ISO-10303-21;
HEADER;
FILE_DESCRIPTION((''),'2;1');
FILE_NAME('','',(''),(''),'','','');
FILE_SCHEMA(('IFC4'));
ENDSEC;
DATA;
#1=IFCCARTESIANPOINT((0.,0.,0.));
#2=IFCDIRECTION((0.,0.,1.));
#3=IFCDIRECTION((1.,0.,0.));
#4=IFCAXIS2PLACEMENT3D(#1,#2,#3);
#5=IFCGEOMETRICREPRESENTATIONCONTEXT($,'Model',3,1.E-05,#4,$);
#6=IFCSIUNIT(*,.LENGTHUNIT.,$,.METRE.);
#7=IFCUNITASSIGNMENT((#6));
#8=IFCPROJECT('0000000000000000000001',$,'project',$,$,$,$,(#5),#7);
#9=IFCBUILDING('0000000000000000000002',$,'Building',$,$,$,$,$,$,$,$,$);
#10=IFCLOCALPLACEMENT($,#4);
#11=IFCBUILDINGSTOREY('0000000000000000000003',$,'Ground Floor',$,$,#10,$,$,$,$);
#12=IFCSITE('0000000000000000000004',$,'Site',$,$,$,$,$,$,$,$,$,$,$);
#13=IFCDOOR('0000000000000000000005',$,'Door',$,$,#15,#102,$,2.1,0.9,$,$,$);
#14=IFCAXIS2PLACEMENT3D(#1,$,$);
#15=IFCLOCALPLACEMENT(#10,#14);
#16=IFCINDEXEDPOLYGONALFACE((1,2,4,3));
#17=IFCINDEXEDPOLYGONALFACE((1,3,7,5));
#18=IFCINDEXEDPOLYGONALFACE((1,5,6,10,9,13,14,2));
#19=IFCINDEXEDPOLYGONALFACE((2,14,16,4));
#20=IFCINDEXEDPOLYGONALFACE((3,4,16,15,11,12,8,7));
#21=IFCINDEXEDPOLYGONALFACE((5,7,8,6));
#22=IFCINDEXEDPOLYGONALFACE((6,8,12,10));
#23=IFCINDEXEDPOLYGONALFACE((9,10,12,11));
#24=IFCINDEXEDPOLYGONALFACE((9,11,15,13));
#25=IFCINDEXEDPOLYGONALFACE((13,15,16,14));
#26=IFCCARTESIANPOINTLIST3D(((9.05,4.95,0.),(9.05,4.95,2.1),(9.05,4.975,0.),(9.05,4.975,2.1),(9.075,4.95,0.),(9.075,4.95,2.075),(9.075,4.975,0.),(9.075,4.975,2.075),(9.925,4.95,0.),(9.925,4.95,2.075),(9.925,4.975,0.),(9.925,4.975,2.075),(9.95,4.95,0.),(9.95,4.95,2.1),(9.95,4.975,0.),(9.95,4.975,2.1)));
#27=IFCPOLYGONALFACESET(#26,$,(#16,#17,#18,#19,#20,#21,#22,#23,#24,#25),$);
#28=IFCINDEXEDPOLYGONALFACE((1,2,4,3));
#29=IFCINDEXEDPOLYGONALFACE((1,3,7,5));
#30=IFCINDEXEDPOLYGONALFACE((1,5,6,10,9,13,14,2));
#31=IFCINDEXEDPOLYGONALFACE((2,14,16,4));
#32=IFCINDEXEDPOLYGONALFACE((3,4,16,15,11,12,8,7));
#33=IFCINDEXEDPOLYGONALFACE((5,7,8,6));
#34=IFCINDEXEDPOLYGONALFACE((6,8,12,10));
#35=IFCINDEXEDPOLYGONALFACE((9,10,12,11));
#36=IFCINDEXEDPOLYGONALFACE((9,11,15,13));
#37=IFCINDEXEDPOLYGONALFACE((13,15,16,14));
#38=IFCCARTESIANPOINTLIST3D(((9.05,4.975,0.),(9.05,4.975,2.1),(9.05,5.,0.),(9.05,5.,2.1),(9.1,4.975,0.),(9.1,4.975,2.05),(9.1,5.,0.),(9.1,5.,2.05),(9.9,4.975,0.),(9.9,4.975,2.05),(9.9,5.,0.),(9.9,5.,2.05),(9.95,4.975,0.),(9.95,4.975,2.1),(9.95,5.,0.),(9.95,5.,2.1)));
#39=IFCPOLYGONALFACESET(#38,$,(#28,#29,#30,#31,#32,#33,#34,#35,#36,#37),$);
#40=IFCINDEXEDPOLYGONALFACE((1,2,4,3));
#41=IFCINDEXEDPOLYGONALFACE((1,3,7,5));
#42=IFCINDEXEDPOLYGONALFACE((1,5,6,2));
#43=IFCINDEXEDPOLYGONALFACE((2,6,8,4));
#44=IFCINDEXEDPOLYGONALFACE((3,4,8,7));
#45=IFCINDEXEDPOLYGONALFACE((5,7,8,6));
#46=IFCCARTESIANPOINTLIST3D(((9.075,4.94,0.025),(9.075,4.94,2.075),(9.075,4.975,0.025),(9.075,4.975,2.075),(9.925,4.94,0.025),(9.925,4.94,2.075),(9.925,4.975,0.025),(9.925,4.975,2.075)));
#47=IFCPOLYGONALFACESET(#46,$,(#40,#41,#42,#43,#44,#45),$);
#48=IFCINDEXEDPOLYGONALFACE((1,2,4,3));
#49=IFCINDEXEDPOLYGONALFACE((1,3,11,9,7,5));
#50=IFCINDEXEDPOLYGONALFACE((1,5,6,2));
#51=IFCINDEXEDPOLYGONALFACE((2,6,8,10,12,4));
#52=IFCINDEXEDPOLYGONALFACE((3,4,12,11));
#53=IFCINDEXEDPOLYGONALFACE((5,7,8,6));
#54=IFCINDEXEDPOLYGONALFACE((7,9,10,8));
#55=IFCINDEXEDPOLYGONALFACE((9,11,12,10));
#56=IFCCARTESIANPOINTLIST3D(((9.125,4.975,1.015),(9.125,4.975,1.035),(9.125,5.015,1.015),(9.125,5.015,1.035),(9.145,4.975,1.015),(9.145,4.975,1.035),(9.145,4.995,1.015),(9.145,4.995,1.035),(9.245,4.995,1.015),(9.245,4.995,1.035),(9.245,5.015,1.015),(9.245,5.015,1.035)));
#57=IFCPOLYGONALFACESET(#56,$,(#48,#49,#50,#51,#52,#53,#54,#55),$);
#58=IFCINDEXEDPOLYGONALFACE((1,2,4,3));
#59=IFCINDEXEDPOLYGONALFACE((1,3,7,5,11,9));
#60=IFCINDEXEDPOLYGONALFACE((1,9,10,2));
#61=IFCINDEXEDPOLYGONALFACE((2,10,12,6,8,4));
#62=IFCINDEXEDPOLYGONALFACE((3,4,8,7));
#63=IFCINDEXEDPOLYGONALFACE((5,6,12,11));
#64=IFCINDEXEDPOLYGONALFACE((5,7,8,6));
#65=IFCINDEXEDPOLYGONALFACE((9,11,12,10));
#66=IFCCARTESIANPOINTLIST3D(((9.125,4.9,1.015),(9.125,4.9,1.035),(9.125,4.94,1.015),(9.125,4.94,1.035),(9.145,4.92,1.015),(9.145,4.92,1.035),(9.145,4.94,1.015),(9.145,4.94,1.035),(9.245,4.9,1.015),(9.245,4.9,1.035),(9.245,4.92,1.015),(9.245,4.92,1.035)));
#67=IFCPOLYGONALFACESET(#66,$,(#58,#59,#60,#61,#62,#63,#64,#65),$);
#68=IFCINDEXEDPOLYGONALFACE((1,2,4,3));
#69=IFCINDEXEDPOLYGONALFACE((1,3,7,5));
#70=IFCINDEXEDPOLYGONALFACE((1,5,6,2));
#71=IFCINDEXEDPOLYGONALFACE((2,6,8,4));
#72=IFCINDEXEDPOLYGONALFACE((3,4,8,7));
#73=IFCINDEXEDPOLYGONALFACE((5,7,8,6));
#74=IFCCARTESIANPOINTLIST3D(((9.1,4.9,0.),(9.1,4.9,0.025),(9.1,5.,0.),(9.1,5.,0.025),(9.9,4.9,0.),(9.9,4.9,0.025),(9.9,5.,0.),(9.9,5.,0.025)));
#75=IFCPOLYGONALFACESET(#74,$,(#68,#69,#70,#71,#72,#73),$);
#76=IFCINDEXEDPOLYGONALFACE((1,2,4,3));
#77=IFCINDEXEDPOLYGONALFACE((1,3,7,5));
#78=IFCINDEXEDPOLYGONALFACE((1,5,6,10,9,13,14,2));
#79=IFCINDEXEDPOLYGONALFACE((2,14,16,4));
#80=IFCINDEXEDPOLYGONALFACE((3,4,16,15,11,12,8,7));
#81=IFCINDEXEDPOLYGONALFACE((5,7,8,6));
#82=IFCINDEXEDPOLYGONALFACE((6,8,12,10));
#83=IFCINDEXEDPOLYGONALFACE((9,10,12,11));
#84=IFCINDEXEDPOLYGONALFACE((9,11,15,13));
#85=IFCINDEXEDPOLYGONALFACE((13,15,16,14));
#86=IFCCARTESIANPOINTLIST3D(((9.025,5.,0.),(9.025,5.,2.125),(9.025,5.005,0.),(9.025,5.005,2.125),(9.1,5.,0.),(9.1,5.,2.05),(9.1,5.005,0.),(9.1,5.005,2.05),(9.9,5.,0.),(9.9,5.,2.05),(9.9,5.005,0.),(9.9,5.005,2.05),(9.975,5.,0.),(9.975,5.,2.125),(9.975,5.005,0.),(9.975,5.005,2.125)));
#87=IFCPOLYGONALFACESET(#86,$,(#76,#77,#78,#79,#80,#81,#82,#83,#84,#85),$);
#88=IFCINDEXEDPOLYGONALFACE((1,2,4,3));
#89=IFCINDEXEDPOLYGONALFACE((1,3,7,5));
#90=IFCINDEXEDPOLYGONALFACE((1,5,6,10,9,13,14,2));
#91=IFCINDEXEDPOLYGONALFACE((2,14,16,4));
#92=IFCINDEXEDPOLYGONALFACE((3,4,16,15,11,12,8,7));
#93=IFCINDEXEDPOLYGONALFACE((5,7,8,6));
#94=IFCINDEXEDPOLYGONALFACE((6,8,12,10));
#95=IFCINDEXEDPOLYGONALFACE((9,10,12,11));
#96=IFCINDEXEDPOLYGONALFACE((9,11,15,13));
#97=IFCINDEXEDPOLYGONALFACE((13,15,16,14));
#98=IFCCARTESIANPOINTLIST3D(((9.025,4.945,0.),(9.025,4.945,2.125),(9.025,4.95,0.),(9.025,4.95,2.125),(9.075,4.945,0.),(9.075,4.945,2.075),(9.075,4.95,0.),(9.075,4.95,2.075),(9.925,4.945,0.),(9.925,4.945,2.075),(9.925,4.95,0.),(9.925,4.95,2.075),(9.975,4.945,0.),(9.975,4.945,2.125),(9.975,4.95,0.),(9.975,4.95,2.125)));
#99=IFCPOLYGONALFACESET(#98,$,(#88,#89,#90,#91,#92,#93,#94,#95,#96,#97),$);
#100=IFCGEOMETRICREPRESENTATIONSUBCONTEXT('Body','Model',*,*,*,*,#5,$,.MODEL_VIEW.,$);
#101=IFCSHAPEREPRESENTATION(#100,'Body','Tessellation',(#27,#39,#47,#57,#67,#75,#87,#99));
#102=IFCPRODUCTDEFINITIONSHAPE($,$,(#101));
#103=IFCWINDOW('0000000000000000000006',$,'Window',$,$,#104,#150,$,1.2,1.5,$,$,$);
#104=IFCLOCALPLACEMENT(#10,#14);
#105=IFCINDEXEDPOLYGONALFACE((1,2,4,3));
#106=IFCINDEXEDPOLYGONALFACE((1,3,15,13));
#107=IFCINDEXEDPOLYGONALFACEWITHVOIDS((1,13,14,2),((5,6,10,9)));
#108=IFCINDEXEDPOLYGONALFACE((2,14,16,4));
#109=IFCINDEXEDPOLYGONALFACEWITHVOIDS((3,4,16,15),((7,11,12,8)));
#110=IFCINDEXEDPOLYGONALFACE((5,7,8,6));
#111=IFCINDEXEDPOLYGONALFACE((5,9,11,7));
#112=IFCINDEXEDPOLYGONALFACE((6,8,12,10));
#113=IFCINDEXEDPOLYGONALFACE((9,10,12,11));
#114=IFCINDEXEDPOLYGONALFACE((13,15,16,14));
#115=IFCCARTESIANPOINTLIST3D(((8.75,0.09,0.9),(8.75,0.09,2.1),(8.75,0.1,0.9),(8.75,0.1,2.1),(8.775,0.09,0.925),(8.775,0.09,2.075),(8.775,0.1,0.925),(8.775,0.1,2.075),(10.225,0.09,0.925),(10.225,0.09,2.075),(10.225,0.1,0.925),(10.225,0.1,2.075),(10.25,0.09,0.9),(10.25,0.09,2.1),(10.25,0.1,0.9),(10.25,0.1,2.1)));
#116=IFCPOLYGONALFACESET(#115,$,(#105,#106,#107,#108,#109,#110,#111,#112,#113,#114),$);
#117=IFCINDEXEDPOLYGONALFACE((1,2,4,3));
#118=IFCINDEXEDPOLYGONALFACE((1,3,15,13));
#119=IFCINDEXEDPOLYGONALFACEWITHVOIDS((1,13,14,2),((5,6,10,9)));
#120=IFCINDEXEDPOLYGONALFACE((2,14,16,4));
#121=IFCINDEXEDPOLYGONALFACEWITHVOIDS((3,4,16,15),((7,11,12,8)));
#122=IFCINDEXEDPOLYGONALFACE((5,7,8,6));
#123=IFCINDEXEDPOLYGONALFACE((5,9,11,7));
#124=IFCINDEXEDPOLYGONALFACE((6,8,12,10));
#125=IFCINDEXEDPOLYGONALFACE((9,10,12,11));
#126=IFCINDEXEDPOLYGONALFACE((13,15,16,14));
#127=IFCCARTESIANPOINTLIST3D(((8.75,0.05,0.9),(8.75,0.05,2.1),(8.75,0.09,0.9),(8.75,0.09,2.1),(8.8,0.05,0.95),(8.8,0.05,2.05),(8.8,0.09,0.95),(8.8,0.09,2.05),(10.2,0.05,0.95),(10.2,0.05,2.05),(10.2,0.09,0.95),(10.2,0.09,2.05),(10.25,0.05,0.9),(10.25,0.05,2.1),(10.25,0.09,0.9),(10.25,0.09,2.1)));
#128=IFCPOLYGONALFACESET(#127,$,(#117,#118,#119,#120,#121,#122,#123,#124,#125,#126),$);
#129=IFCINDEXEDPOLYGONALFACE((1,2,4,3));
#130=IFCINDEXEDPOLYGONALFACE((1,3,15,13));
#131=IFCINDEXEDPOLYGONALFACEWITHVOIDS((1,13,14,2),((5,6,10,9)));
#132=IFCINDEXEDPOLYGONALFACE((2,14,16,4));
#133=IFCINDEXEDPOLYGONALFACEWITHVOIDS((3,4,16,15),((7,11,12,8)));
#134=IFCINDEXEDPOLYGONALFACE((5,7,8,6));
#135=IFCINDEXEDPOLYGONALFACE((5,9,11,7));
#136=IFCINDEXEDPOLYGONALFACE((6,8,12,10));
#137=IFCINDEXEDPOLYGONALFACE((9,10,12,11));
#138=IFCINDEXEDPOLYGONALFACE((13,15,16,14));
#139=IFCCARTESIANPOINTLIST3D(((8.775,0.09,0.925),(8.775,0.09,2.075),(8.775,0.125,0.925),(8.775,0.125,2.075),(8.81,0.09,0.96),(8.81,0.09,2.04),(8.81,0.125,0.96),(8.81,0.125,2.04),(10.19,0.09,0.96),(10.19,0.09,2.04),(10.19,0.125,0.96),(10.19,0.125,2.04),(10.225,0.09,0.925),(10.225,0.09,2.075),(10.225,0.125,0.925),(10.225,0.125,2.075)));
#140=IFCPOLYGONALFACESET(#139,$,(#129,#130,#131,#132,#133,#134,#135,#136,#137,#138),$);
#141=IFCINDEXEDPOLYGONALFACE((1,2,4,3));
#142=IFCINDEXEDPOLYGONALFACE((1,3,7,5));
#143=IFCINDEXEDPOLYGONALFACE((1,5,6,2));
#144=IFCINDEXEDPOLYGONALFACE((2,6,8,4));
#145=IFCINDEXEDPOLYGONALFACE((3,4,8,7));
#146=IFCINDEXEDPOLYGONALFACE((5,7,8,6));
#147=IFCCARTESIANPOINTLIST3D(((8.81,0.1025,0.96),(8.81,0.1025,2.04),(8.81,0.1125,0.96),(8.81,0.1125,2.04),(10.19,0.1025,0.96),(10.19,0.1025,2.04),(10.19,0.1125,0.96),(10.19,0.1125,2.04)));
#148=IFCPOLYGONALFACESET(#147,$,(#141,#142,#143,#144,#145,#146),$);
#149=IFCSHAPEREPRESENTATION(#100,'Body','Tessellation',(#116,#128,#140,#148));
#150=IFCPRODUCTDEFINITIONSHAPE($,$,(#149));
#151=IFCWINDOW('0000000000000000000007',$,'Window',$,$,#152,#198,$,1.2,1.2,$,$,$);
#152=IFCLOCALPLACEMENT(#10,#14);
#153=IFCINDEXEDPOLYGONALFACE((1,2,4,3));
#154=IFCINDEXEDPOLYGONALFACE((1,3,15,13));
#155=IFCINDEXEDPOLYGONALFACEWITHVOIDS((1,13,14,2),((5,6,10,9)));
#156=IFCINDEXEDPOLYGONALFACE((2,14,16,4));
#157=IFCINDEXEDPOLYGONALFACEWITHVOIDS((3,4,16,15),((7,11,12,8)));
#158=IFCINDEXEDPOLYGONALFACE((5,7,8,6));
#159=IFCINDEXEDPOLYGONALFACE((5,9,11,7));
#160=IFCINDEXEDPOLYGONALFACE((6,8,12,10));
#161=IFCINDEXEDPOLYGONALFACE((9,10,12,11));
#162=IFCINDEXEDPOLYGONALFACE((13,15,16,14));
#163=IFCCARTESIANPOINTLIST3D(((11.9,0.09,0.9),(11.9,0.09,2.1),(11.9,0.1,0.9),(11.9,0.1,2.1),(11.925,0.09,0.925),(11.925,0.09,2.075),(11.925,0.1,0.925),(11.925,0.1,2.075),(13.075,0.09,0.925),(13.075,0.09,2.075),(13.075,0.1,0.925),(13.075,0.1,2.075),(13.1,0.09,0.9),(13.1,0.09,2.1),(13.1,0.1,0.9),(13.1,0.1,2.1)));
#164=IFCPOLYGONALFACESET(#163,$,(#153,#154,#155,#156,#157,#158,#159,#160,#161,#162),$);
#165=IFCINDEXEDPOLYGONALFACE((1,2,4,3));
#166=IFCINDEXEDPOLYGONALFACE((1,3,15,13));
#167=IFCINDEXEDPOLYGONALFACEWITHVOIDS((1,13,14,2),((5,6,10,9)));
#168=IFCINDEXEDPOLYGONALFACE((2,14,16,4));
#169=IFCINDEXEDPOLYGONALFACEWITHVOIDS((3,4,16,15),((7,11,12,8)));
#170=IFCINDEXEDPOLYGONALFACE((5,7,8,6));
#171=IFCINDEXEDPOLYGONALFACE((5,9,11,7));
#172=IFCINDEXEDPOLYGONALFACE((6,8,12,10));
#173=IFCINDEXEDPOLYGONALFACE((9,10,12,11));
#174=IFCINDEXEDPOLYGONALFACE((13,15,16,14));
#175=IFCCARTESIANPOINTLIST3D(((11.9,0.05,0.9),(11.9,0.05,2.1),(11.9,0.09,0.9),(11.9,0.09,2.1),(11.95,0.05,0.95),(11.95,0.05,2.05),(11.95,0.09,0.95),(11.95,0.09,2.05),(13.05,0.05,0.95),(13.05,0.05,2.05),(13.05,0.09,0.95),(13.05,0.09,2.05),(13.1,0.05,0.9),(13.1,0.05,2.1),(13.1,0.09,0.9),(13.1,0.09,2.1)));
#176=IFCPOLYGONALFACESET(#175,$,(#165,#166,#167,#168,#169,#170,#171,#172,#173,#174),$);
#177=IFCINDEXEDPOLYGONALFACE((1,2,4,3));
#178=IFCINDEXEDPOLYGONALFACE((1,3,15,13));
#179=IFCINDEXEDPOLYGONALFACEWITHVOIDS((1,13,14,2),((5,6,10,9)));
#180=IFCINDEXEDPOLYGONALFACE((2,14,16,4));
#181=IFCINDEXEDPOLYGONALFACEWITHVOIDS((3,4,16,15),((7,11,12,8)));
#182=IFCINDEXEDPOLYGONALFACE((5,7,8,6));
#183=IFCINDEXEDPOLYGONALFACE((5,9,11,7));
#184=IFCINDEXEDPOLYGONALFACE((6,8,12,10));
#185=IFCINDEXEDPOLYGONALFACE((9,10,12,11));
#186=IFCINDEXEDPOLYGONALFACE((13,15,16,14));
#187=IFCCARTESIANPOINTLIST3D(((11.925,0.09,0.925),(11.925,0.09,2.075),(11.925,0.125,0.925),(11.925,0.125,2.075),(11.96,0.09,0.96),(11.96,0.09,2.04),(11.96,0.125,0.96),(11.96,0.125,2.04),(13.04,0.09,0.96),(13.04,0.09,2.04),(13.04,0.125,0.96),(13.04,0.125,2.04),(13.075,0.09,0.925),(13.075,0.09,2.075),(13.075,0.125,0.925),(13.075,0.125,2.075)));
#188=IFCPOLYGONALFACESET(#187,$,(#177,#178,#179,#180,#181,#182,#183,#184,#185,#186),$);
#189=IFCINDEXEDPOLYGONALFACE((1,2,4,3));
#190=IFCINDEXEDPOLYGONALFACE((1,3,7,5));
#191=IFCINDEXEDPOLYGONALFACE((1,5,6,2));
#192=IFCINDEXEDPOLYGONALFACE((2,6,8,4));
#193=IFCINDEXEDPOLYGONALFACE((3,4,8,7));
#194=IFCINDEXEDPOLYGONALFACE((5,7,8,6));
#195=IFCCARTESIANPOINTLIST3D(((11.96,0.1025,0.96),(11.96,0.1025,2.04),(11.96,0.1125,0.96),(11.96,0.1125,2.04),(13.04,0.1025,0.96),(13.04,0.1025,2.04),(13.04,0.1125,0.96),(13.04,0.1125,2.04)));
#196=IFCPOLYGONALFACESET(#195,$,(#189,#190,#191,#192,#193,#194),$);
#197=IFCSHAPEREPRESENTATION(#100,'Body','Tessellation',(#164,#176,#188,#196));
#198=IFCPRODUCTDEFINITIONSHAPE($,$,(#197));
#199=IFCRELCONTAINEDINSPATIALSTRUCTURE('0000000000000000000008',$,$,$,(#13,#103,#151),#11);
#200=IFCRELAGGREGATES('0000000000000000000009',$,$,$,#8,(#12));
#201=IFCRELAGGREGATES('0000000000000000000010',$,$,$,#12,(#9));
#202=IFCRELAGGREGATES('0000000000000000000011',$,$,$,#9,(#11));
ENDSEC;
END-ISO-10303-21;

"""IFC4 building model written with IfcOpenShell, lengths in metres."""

from ifc_helpers import new_model, si_unit, frame, origin_with_axes, place, context, subcontext, project, spatial, line, indexed_curve, outline, extrude, element, save


model = new_model("IFC4")

# Units and contexts
model_context = context("Model", 3, precision=1e-05, world=origin_with_axes())
body_context = subcontext(model_context, "Body", "Model", "MODEL_VIEW")
ifc_project = project(units=[si_unit("LENGTHUNIT", "METRE")], contexts=[model_context])

# Site, building, storey
site = spatial("IfcSite", under=ifc_project, Name="Site")
building = spatial("IfcBuilding", under=site, Name="Building")
storey_placement = place(None, origin_with_axes())
storey = spatial("IfcBuildingStorey", under=building, at=storey_placement, Name="Ground Floor")

# Door
door_1_placement = place(storey_placement, frame((9.95, 5.0, 0.0), z_axis=(0.0, 0.0, 1.0), x_axis=(-1.0, 0.0, 0.0)))
element("IfcDoor", 1, at=door_1_placement, inside=storey, Name="Door", OverallHeight=2.1, OverallWidth=0.9, context=body_context, shape_type="SweptSolid", body=[
    extrude(outline(indexed_curve([(0.0, 0.0), (0.0, 2.1), (0.9, 2.1), (0.9, 0.0), (0.875, 0.0), (0.875, 2.075), (0.025, 2.075), (0.025, 0.0)], segments=[line(1, 2, 3, 4, 5, 6, 7, 8, 1)])), frame((0.0, 0.025, 0.0), z_axis=(0.0, -1.0, 0.0), x_axis=(1.0, 0.0, 0.0)), (0.0, 0.0, -1.0), 0.025),
    extrude(outline(indexed_curve([(0.0, 0.0), (0.0, 2.1), (0.9, 2.1), (0.9, 0.0), (0.85, 0.0), (0.85, 2.05), (0.05, 2.05), (0.05, 0.0)], segments=[line(1, 2, 3, 4, 5, 6, 7, 8, 1)])), frame((0.0, 0.0, 0.0), z_axis=(0.0, -1.0, 0.0), x_axis=(1.0, 0.0, 0.0)), (0.0, 0.0, -1.0), 0.025),
    extrude(outline(indexed_curve([(0.0, 0.0), (0.85, 0.0), (0.85, 0.035), (0.0, 0.035)], segments=[line(1, 2, 3, 4, 1)])), frame((0.025, 0.025, 0.025), z_axis=(0.0, 0.0, 1.0), x_axis=(1.0, 0.0, 0.0)), (0.0, 0.0, 1.0), 2.05),
    extrude(outline(indexed_curve([(0.0, 0.0), (0.0, -0.04), (-0.12, -0.04), (-0.12, -0.02), (-0.02, -0.02), (-0.02, 0.0)], segments=[line(1, 2, 3, 4, 5, 6, 1)])), frame((0.825, 0.025, 1.015), z_axis=(0.0, 0.0, 1.0), x_axis=(1.0, 0.0, 0.0)), (0.0, 0.0, 1.0), 0.02),
    extrude(outline(indexed_curve([(0.0, 0.0), (0.0, 0.04), (-0.12, 0.04), (-0.12, 0.02), (-0.02, 0.02), (-0.02, 0.0)], segments=[line(1, 2, 3, 4, 5, 6, 1)])), frame((0.825, 0.06, 1.015), z_axis=(0.0, 0.0, 1.0), x_axis=(1.0, 0.0, 0.0)), (0.0, 0.0, 1.0), 0.02),
    extrude(outline(indexed_curve([(0.0, 0.0), (0.8, 0.0), (0.8, 0.1), (0.0, 0.1)], segments=[line(1, 2, 3, 4, 1)])), frame((0.05, 0.0, 0.0), z_axis=(0.0, 0.0, 1.0), x_axis=(1.0, 0.0, 0.0)), (0.0, 0.0, 1.0), 0.025),
    extrude(outline(indexed_curve([(0.0, 0.0), (0.0, 2.125), (0.95, 2.125), (0.95, 0.0), (0.875, 0.0), (0.875, 2.05), (0.075, 2.05), (0.075, 0.0)], segments=[line(1, 2, 3, 4, 5, 6, 7, 8, 1)])), frame((-0.025, -0.005, 0.0), z_axis=(0.0, -1.0, 0.0), x_axis=(1.0, 0.0, 0.0)), (0.0, 0.0, -1.0), 0.005),
    extrude(outline(indexed_curve([(0.0, 0.0), (0.0, 2.125), (0.95, 2.125), (0.95, 0.0), (0.9, 0.0), (0.9, 2.075), (0.05, 2.075), (0.05, 0.0)], segments=[line(1, 2, 3, 4, 5, 6, 7, 8, 1)])), frame((-0.025, 0.05, 0.0), z_axis=(0.0, -1.0, 0.0), x_axis=(1.0, 0.0, 0.0)), (0.0, 0.0, -1.0), 0.005),
])

# Windows
window_1_placement = place(storey_placement, frame((8.75, 0.0, 0.9), z_axis=(0.0, 0.0, 1.0), x_axis=(1.0, 0.0, 0.0)))
element("IfcWindow", 2, at=window_1_placement, inside=storey, Name="Window", OverallHeight=1.2, OverallWidth=1.5, context=body_context, shape_type="SweptSolid", body=[
    extrude(outline(indexed_curve([(0.0, 0.0), (1.5, 0.0), (1.5, 1.2), (0.0, 1.2)], segments=[line(1, 2, 3, 4, 1)]), holes=[indexed_curve([(0.025, 0.025), (1.475, 0.025), (1.475, 1.175), (0.025, 1.175)], segments=[line(1, 2, 3, 4, 1)])]), frame((0.0, 0.09, 0.0), z_axis=(0.0, -1.0, 0.0), x_axis=(1.0, 0.0, 0.0)), (0.0, 0.0, -1.0), 0.01),
    extrude(outline(indexed_curve([(0.0, 0.0), (1.5, 0.0), (1.5, 1.2), (0.0, 1.2)], segments=[line(1, 2, 3, 4, 1)]), holes=[indexed_curve([(0.05, 0.05), (1.45, 0.05), (1.45, 1.15), (0.05, 1.15)], segments=[line(1, 2, 3, 4, 1)])]), frame((0.0, 0.05, 0.0), z_axis=(0.0, -1.0, 0.0), x_axis=(1.0, 0.0, 0.0)), (0.0, 0.0, -1.0), 0.04),
    extrude(outline(indexed_curve([(0.0, 0.0), (1.45, 0.0), (1.45, 1.15), (0.0, 1.15)], segments=[line(1, 2, 3, 4, 1)]), holes=[indexed_curve([(0.035, 0.035), (1.415, 0.035), (1.415, 1.115), (0.035, 1.115)], segments=[line(1, 2, 3, 4, 1)])]), frame((0.025, 0.09, 0.025), z_axis=(0.0, -1.0, 0.0), x_axis=(1.0, 0.0, 0.0)), (0.0, 0.0, -1.0), 0.035),
    extrude(outline(indexed_curve([(0.035, 0.035), (1.415, 0.035), (1.415, 1.115), (0.035, 1.115)], segments=[line(1, 2, 3, 4, 1)])), frame((0.025, 0.1025, 0.025), z_axis=(0.0, -1.0, 0.0), x_axis=(1.0, 0.0, 0.0)), (0.0, 0.0, -1.0), 0.01),
])
window_2_placement = place(storey_placement, frame((11.9, 0.0, 0.9), z_axis=(0.0, 0.0, 1.0), x_axis=(1.0, 0.0, 0.0)))
element("IfcWindow", 3, at=window_2_placement, inside=storey, Name="Window", OverallHeight=1.2, OverallWidth=1.2, context=body_context, shape_type="SweptSolid", body=[
    extrude(outline(indexed_curve([(0.0, 0.0), (1.2, 0.0), (1.2, 1.2), (0.0, 1.2)], segments=[line(1, 2, 3, 4, 1)]), holes=[indexed_curve([(0.025, 0.025), (1.175, 0.025), (1.175, 1.175), (0.025, 1.175)], segments=[line(1, 2, 3, 4, 1)])]), frame((0.0, 0.09, 0.0), z_axis=(0.0, -1.0, 0.0), x_axis=(1.0, 0.0, 0.0)), (0.0, 0.0, -1.0), 0.01),
    extrude(outline(indexed_curve([(0.0, 0.0), (1.2, 0.0), (1.2, 1.2), (0.0, 1.2)], segments=[line(1, 2, 3, 4, 1)]), holes=[indexed_curve([(0.05, 0.05), (1.15, 0.05), (1.15, 1.15), (0.05, 1.15)], segments=[line(1, 2, 3, 4, 1)])]), frame((0.0, 0.05, 0.0), z_axis=(0.0, -1.0, 0.0), x_axis=(1.0, 0.0, 0.0)), (0.0, 0.0, -1.0), 0.04),
    extrude(outline(indexed_curve([(0.0, 0.0), (1.15, 0.0), (1.15, 1.15), (0.0, 1.15)], segments=[line(1, 2, 3, 4, 1)]), holes=[indexed_curve([(0.035, 0.035), (1.115, 0.035), (1.115, 1.115), (0.035, 1.115)], segments=[line(1, 2, 3, 4, 1)])]), frame((0.025, 0.09, 0.025), z_axis=(0.0, -1.0, 0.0), x_axis=(1.0, 0.0, 0.0)), (0.0, 0.0, -1.0), 0.035),
    extrude(outline(indexed_curve([(0.035, 0.035), (1.115, 0.035), (1.115, 1.115), (0.035, 1.115)], segments=[line(1, 2, 3, 4, 1)])), frame((0.025, 0.1025, 0.025), z_axis=(0.0, -1.0, 0.0), x_axis=(1.0, 0.0, 0.0)), (0.0, 0.0, -1.0), 0.01),
])

save(model, "model.ifc")
